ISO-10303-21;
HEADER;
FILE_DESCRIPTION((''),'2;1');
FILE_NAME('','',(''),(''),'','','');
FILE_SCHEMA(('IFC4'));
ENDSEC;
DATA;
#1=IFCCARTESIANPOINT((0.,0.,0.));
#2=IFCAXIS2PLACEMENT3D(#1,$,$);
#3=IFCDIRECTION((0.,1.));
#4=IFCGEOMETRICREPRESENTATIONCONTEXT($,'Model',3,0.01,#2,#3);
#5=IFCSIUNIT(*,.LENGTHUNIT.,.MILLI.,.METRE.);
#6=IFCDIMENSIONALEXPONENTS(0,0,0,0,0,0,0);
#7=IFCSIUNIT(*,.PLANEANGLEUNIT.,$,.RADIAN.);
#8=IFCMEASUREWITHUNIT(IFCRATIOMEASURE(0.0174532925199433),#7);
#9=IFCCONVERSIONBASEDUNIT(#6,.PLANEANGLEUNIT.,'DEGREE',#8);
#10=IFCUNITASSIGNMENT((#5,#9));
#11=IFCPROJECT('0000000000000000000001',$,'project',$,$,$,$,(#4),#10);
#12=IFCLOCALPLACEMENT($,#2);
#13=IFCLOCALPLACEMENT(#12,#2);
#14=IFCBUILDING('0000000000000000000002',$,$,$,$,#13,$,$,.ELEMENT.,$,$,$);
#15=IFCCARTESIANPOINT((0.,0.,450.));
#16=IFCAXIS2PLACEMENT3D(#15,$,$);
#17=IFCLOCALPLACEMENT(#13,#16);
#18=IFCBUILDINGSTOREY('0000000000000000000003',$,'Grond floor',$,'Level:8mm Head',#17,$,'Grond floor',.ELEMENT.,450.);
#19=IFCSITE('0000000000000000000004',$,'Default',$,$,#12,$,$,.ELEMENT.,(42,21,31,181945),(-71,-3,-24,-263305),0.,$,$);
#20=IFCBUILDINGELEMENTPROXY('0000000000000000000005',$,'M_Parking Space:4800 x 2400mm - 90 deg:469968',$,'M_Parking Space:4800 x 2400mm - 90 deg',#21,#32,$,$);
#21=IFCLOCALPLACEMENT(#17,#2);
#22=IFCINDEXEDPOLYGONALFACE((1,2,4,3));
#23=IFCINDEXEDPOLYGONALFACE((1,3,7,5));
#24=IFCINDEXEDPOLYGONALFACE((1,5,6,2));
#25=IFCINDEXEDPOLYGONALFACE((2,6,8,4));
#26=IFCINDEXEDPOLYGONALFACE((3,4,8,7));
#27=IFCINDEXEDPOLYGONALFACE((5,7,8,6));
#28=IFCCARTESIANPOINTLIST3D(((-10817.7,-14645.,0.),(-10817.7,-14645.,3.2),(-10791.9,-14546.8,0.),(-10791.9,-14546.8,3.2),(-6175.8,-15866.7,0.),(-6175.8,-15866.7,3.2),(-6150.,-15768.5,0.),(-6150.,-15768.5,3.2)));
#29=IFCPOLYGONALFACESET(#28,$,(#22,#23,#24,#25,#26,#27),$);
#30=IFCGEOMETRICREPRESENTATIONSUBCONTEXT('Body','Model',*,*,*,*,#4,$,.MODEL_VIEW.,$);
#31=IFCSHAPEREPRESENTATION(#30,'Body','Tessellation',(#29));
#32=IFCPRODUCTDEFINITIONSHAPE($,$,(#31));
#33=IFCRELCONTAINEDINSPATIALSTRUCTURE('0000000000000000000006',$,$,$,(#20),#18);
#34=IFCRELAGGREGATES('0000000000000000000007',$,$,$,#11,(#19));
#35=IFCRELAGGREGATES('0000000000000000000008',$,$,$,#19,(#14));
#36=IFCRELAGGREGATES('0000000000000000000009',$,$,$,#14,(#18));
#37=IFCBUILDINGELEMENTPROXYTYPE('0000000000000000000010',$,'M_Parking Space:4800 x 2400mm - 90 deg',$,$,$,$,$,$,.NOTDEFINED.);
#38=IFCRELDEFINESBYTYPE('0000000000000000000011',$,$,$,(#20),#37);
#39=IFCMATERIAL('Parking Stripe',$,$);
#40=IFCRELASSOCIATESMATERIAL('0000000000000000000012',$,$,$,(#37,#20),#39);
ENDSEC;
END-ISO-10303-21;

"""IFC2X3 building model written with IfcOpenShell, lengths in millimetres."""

from ifc_helpers import new_model, entity, si_unit, converted_unit, direction, frame, origin, origin_2d_with_axis, place, context, subcontext, project, spatial, rectangle, extrude, source, transform, mapped, material, type_object, type_shapes, element, save


model = new_model("IFC2X3")

# Units and contexts
model_context = context("Model", 3, precision=0.01, world=origin(), true_north=direction((0.0, 1.0)))
body_context = subcontext(model_context, "Body", "Model", "MODEL_VIEW")
ifc_project = project(units=[si_unit("LENGTHUNIT", "METRE", prefix="MILLI"), converted_unit("PLANEANGLEUNIT", "DEGREE", entity("IfcRatioMeasure", 0.0174532925199433), si_unit("PLANEANGLEUNIT", "RADIAN"), dimensions=[0, 0, 0, 0, 0, 0, 0])], contexts=[model_context])

# Site, building, storey
site_placement = place(None, origin())
site = spatial("IfcSite", under=ifc_project, at=site_placement, Name="Default", CompositionType="ELEMENT", RefLatitude=(42, 21, 31, 181945), RefLongitude=(-71, -3, -24, -263305), RefElevation=0.0)
building_placement = place(site_placement, origin())
building = spatial("IfcBuilding", under=site, at=building_placement, CompositionType="ELEMENT")
storey_placement = place(building_placement, frame((0.0, 0.0, 450.0)))
storey = spatial("IfcBuildingStorey", under=building, at=storey_placement, Name="Grond floor", ObjectType="Level:8mm Head", LongName="Grond floor", CompositionType="ELEMENT", Elevation=450.0)

# Building element proxy
ifc_material_1 = material(Name="Parking Stripe")
building_element_proxy_type = type_object("IfcBuildingElementProxyType", Name="M_Parking Space:4800 x 2400mm - 90 deg", PredefinedType="NOTDEFINED", material=ifc_material_1)
shared_shape_1 = source(origin(), body_context, "Body", "SweptSolid", [
    extrude(rectangle(XDim=101.6, YDim=4800.0, at=origin_2d_with_axis()), frame((0.0, 2400.0, 0.0)), (0.0, 0.0, 1.0), 3.2),
])
type_shapes(building_element_proxy_type, [shared_shape_1])
proxy_placement = place(storey_placement, frame((-6162.9, -15817.6, 0.0), z_axis=(0.0, 0.0, 1.0), x_axis=(0.25452, 0.967067, 0.0)))
element("IfcBuildingElementProxy", 1, at=proxy_placement, inside=storey, type_object=building_element_proxy_type, material=ifc_material_1, Name="M_Parking Space:4800 x 2400mm - 90 deg:469968", ObjectType="M_Parking Space:4800 x 2400mm - 90 deg", context=body_context, shape_type="MappedRepresentation", body=[
    mapped(shared_shape_1, transform((0.0, 0.0, 0.0), scale=1.0)),
])

save(model, "model.ifc")
